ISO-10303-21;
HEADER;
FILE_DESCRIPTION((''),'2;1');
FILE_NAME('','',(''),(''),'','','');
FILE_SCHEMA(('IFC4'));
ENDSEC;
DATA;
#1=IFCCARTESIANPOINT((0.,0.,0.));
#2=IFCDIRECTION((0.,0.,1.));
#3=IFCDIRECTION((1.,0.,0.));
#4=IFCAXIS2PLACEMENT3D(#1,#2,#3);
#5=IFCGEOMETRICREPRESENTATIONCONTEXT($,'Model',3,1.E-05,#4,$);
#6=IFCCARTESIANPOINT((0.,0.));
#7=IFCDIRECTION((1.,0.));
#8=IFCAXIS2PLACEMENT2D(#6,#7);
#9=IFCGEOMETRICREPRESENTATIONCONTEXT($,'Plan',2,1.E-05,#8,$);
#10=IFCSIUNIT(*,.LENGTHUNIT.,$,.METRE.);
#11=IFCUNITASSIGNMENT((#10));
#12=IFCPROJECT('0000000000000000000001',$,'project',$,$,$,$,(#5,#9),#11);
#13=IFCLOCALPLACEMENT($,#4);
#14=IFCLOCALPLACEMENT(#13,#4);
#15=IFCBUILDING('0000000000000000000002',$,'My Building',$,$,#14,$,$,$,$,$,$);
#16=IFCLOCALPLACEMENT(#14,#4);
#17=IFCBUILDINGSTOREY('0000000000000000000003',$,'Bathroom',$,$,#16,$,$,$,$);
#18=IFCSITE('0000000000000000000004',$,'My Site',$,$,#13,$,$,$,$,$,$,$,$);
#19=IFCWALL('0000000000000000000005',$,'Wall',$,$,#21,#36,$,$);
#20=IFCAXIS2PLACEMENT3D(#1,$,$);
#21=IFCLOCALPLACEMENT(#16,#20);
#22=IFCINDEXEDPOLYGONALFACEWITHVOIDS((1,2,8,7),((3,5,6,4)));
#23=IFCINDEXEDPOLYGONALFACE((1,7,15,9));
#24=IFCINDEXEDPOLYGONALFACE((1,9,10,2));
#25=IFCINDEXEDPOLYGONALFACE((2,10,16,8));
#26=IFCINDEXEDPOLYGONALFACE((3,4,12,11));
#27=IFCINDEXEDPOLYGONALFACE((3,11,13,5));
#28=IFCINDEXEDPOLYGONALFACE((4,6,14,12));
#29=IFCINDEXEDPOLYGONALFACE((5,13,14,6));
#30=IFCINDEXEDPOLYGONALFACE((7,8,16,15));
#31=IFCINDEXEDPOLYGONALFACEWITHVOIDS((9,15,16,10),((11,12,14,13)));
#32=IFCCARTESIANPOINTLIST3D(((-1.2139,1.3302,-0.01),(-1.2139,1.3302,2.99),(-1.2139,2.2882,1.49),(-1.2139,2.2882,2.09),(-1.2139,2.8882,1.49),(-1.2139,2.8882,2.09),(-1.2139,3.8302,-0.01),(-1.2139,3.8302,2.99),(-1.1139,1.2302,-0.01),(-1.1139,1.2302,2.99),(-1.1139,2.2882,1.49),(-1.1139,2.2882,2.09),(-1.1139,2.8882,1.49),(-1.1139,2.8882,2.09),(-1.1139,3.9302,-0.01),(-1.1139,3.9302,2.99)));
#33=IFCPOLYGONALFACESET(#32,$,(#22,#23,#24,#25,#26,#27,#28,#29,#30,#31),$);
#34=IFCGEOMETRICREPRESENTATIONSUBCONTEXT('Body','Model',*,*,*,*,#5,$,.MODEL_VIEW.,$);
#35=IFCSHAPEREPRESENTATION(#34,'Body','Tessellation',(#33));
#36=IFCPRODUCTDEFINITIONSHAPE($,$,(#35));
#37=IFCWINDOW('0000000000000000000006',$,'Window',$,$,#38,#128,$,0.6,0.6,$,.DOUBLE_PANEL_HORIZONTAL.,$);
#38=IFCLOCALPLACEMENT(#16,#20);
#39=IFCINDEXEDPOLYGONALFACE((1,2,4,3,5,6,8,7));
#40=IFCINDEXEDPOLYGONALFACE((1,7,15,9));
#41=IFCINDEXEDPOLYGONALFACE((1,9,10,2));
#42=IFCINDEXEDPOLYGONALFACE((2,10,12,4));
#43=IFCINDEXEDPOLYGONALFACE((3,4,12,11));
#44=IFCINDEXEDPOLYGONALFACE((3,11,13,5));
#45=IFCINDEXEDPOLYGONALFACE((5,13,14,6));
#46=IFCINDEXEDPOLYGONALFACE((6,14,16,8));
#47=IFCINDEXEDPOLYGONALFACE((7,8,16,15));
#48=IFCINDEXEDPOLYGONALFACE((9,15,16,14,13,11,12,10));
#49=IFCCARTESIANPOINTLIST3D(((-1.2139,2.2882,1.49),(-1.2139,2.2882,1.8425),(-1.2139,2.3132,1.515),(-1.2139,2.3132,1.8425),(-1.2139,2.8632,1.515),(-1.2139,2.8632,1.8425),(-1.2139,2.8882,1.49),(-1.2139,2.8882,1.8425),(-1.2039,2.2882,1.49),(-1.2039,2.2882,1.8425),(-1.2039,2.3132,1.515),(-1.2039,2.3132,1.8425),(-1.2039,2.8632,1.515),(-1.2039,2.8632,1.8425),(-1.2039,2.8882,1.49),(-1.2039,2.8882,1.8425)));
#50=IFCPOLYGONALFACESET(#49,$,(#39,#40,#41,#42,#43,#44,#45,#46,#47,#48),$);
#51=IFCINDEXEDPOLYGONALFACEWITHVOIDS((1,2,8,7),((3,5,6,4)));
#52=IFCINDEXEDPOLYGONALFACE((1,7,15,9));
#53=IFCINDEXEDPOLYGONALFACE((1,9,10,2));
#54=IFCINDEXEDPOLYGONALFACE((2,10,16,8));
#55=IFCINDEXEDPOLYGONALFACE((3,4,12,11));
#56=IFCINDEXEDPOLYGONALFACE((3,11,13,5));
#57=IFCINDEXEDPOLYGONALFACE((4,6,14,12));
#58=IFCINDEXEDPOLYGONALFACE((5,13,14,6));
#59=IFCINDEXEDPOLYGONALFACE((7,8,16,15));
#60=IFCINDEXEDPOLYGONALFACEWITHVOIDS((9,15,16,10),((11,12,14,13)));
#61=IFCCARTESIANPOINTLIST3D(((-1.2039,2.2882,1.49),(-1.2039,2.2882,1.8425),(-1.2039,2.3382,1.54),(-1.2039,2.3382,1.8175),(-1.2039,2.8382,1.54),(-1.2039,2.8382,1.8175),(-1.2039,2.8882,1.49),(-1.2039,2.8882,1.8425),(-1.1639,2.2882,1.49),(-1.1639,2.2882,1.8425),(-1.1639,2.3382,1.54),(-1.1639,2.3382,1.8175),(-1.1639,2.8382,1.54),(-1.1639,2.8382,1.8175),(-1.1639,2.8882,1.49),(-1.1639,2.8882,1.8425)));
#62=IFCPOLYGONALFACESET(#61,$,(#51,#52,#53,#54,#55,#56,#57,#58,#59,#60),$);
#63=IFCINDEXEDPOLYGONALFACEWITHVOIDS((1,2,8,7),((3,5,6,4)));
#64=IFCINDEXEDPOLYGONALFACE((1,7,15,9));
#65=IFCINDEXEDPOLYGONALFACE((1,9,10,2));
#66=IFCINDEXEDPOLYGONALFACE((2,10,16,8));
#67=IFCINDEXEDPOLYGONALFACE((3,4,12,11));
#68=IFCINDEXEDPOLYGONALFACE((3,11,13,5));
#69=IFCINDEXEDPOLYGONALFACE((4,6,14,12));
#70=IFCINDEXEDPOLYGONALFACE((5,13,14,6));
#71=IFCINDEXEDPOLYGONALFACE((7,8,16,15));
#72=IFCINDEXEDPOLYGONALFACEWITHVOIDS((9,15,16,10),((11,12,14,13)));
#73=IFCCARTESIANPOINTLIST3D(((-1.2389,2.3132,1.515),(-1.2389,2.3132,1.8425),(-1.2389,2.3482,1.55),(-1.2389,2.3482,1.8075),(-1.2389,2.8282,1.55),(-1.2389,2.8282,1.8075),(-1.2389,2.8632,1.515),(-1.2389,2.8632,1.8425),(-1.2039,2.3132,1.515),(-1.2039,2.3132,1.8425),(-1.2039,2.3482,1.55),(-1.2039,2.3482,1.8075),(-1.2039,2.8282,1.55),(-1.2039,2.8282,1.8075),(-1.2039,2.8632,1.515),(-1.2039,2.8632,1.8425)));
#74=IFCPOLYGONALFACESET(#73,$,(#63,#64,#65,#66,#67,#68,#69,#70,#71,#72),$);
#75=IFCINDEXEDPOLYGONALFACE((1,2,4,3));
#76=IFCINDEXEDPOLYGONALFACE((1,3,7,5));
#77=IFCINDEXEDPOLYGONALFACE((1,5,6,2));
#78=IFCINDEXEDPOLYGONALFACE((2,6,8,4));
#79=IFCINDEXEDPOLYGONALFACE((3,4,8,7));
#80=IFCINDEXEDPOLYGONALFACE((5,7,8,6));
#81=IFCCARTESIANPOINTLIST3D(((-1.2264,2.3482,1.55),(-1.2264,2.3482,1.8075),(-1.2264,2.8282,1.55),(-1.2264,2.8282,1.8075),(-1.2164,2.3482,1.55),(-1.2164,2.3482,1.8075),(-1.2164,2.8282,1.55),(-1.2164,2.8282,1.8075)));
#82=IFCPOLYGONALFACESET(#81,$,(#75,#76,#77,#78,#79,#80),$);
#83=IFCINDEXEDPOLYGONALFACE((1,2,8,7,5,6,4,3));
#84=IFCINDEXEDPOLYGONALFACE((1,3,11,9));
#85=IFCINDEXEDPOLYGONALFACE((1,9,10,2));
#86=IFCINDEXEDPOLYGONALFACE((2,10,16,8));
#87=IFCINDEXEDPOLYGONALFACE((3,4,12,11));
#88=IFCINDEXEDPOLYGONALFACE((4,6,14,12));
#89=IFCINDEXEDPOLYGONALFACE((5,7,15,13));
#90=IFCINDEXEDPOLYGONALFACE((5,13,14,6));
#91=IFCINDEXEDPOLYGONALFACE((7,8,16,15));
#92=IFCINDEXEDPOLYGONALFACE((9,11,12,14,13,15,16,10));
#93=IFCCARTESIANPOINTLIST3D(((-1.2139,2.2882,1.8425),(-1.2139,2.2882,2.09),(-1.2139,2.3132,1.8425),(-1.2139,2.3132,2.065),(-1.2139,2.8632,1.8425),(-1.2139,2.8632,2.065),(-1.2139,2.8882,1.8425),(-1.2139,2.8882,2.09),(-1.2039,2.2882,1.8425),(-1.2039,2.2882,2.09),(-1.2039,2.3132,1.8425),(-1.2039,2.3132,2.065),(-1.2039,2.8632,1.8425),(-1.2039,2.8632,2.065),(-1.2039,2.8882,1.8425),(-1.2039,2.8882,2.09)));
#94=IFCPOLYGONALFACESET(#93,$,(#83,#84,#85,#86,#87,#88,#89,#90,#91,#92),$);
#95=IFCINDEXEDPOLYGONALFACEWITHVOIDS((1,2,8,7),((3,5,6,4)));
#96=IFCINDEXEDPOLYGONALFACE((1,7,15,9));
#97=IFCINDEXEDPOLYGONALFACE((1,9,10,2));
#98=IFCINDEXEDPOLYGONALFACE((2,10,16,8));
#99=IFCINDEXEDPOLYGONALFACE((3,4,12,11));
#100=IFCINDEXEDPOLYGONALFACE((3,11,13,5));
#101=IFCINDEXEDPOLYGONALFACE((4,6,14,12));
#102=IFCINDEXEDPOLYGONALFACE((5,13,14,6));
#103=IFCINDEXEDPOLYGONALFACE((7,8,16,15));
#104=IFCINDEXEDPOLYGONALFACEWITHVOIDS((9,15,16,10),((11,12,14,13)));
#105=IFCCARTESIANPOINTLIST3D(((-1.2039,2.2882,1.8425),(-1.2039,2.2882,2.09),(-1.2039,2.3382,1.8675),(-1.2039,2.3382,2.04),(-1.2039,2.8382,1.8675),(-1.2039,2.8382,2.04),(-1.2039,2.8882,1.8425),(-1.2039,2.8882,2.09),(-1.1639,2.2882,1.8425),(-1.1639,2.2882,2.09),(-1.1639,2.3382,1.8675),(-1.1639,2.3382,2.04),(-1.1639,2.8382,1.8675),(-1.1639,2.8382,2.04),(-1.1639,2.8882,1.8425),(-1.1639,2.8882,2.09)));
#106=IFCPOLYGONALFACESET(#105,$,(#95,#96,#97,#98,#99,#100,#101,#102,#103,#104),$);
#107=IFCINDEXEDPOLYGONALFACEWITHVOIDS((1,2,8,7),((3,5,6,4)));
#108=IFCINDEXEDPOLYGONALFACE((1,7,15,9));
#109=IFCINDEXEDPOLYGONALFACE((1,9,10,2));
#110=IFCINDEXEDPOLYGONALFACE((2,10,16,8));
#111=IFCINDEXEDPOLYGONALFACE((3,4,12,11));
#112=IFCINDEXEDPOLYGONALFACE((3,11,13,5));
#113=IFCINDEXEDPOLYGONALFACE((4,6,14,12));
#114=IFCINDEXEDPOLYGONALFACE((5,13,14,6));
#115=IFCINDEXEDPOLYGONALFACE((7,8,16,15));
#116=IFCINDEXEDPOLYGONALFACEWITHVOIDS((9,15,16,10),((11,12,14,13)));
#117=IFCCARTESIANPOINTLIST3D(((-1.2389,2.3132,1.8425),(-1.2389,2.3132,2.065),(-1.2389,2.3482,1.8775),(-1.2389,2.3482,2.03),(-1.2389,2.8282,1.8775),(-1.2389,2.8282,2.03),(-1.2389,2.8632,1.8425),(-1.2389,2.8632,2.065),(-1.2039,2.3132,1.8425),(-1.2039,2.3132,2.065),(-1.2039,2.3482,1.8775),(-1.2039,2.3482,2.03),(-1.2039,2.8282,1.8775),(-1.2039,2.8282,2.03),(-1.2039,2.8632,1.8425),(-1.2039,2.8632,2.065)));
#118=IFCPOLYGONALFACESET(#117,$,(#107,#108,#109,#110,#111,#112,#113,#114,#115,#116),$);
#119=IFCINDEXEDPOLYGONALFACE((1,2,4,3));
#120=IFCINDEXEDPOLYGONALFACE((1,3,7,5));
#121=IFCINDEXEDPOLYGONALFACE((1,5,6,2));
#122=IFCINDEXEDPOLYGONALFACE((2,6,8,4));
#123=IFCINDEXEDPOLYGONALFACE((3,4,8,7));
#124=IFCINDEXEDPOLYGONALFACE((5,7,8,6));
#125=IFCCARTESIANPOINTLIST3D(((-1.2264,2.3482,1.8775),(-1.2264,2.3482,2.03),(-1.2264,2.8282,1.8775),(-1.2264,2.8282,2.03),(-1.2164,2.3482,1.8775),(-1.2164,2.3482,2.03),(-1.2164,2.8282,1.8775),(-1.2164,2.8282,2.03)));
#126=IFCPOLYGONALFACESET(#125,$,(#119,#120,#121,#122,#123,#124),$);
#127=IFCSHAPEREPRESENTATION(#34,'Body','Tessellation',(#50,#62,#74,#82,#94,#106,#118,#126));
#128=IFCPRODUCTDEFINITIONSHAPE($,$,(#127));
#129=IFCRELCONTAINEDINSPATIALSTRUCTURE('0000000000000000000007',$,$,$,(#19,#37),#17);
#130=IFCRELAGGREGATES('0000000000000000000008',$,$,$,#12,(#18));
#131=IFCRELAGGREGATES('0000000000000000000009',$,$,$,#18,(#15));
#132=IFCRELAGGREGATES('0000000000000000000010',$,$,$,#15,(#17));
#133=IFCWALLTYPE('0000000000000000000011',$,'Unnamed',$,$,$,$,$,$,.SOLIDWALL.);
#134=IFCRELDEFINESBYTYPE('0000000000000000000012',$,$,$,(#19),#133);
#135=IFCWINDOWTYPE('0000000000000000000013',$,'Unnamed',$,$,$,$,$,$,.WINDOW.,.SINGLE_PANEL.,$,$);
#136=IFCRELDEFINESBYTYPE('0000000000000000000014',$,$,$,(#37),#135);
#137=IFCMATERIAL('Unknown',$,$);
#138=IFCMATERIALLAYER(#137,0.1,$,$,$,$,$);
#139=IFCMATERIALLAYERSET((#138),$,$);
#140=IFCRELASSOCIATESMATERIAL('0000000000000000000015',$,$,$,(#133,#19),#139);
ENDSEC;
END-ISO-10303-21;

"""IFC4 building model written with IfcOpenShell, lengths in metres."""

from ifc_helpers import new_model, entity, si_unit, frame, origin_with_axes, origin_2d_with_axis, place, context, subcontext, project, spatial, line, indexed_curve, outline, extrude, shape, source, transform, mapped, material, layer, layer_set, layer_usage, type_object, type_shapes, element, fill, save


model = new_model("IFC4")

# Units and contexts
model_context = context("Model", 3, precision=1e-05, world=origin_with_axes())
plan_context = context("Plan", 2, precision=1e-05, world=origin_2d_with_axis())
body_context_1 = subcontext(model_context, "Body", "Model", "MODEL_VIEW")
body_context_2 = subcontext(plan_context, "Body", "Plan", "PLAN_VIEW")
ifc_project = project(units=[si_unit("LENGTHUNIT", "METRE")], contexts=[model_context, plan_context])

# Site, building, storey
site_placement = place(None, origin_with_axes())
site = spatial("IfcSite", under=ifc_project, at=site_placement, Name="My Site")
building_placement = place(site_placement, origin_with_axes())
building = spatial("IfcBuilding", under=site, at=building_placement, Name="My Building")
storey_placement = place(building_placement, origin_with_axes())
storey = spatial("IfcBuildingStorey", under=building, at=storey_placement, Name="Bathroom")

# Shared definitions
ifc_material = material(Name="Unknown")

# Shared definitions
ifc_layer_1 = layer(ifc_material, 0.1)
ifc_layer_set_1 = layer_set([ifc_layer_1])
wall_type = type_object("IfcWallType", Name="Unnamed", PredefinedType="SOLIDWALL", material=ifc_layer_set_1)

# Wall, opening, window
ifc_layer_usage_1 = layer_usage(ifc_layer_set_1, "AXIS2", "POSITIVE", 0.0)
wall_1_placement = place(storey_placement, frame((-1.2139, 3.8302, -0.01), z_axis=(0.0, 0.0, 1.0), x_axis=(0.0, -1.0, 0.0)))
wall_1 = element("IfcWall", 1, at=wall_1_placement, inside=storey, type_object=wall_type, material=ifc_layer_usage_1, Name="Wall", context=body_context_1, shape_type="SweptSolid", body=[
    extrude(outline(indexed_curve([(0.0, 0.0), (-0.1, 0.1), (2.6, 0.1), (2.5, 0.0)], segments=[line(1, 2, 3, 4, 1)])), origin_with_axes(), (0.0, 0.0, 1.0), 3.0),
])
shared_shape_1 = source(origin_with_axes(), body_context_1, "Body", "SweptSolid", [
    extrude(outline(indexed_curve([(0.0, 0.0), (0.6, 0.0), (0.6, 0.6), (0.0, 0.6)], segments=[line(1, 2, 3, 4, 1)])), frame((0.0, -0.6, 0.0), z_axis=(0.0, -1.0, 0.0), x_axis=(1.0, 0.0, 0.0)), (0.0, 0.0, -1.0), 1.2),
])
opening_1_placement = place(wall_1_placement, frame((1.542, 0.1, 1.5), z_axis=(0.0, 0.0, 1.0), x_axis=(-1.0, 0.0, 0.0)))
opening_1 = element("IfcOpeningElement", 2, at=opening_1_placement, cuts=wall_1, PredefinedType="OPENING", context=body_context_1, shape_type="MappedRepresentation", body=[
    mapped(shared_shape_1, transform((0.0, 0.0, 0.0), x_axis=(1.0, 0.0, 0.0), y_axis=(0.0, 1.0, 0.0), z_axis=(0.0, 0.0, 1.0), scale=1.0)),
])
window_type = type_object("IfcWindowType", Name="Unnamed", PartitioningType="SINGLE_PANEL", PredefinedType="WINDOW")
shared_shape_2 = source(origin_with_axes(), body_context_1, "Body", "SweptSolid", [
    extrude(outline(indexed_curve([(0.6, 0.3525), (0.6, 0.0), (0.0, 0.0), (0.0, 0.3525), (0.025, 0.3525), (0.025, 0.025), (0.575, 0.025), (0.575, 0.3525)], segments=[line(1, 2, 3, 4, 5, 6, 7, 8, 1)])), frame((0.0, 0.09, 0.0), z_axis=(0.0, -1.0, 0.0), x_axis=(1.0, 0.0, 0.0)), (0.0, 0.0, -1.0), 0.01),
    extrude(outline(indexed_curve([(0.0, 0.0), (0.6, 0.0), (0.6, 0.3525), (0.0, 0.3525)], segments=[line(1, 2, 3, 4, 1)]), holes=[indexed_curve([(0.05, 0.05), (0.55, 0.05), (0.55, 0.3275), (0.05, 0.3275)], segments=[line(1, 2, 3, 4, 1)])]), frame((0.0, 0.05, 0.0), z_axis=(0.0, -1.0, 0.0), x_axis=(1.0, 0.0, 0.0)), (0.0, 0.0, -1.0), 0.04),
    extrude(outline(indexed_curve([(0.0, 0.0), (0.55, 0.0), (0.55, 0.3275), (0.0, 0.3275)], segments=[line(1, 2, 3, 4, 1)]), holes=[indexed_curve([(0.035, 0.035), (0.515, 0.035), (0.515, 0.2925), (0.035, 0.2925)], segments=[line(1, 2, 3, 4, 1)])]), frame((0.025, 0.09, 0.025), z_axis=(0.0, -1.0, 0.0), x_axis=(1.0, 0.0, 0.0)), (0.0, 0.0, -1.0), 0.035),
    extrude(outline(indexed_curve([(0.035, 0.035), (0.515, 0.035), (0.515, 0.2925), (0.035, 0.2925)], segments=[line(1, 2, 3, 4, 1)])), frame((0.025, 0.1025, 0.025), z_axis=(0.0, -1.0, 0.0), x_axis=(1.0, 0.0, 0.0)), (0.0, 0.0, -1.0), 0.01),
    extrude(outline(indexed_curve([(0.0, 0.0), (0.0, 0.2475), (0.6, 0.2475), (0.6, 0.0), (0.575, 0.0), (0.575, 0.2225), (0.025, 0.2225), (0.025, 0.0)], segments=[line(1, 2, 3, 4, 5, 6, 7, 8, 1)])), frame((0.0, 0.09, 0.3525), z_axis=(0.0, -1.0, 0.0), x_axis=(1.0, 0.0, 0.0)), (0.0, 0.0, -1.0), 0.01),
    extrude(outline(indexed_curve([(0.0, 0.0), (0.6, 0.0), (0.6, 0.2475), (0.0, 0.2475)], segments=[line(1, 2, 3, 4, 1)]), holes=[indexed_curve([(0.05, 0.025), (0.55, 0.025), (0.55, 0.1975), (0.05, 0.1975)], segments=[line(1, 2, 3, 4, 1)])]), frame((0.0, 0.05, 0.3525), z_axis=(0.0, -1.0, 0.0), x_axis=(1.0, 0.0, 0.0)), (0.0, 0.0, -1.0), 0.04),
    extrude(outline(indexed_curve([(0.0, 0.0), (0.55, 0.0), (0.55, 0.2225), (0.0, 0.2225)], segments=[line(1, 2, 3, 4, 1)]), holes=[indexed_curve([(0.035, 0.035), (0.515, 0.035), (0.515, 0.1875), (0.035, 0.1875)], segments=[line(1, 2, 3, 4, 1)])]), frame((0.025, 0.09, 0.3525), z_axis=(0.0, -1.0, 0.0), x_axis=(1.0, 0.0, 0.0)), (0.0, 0.0, -1.0), 0.035),
    extrude(outline(indexed_curve([(0.035, 0.035), (0.515, 0.035), (0.515, 0.1875), (0.035, 0.1875)], segments=[line(1, 2, 3, 4, 1)])), frame((0.025, 0.1025, 0.3525), z_axis=(0.0, -1.0, 0.0), x_axis=(1.0, 0.0, 0.0)), (0.0, 0.0, -1.0), 0.01),
])
shared_shape_3 = source(origin_with_axes(), body_context_2, "Body", "Curve2D", [
    entity("IfcIndexedPolyCurve", entity("IfcCartesianPointList2D", [[0.05, 0.05], [0.55, 0.05]])),
    entity("IfcIndexedPolyCurve", entity("IfcCartesianPointList2D", [[0.0, 0.1], [0.025, 0.1], [0.025, 0.09], [0.05, 0.09], [0.05, 0.05], [0.0, 0.05]]), [entity("IfcLineIndex", [1, 2, 3, 4, 5, 6, 1])]),
    entity("IfcIndexedPolyCurve", entity("IfcCartesianPointList2D", [[0.6, 0.1], [0.575, 0.1], [0.575, 0.09], [0.55, 0.09], [0.55, 0.05], [0.6, 0.05]]), [entity("IfcLineIndex", [1, 2, 3, 4, 5, 6, 1])]),
    entity("IfcIndexedPolyCurve", entity("IfcCartesianPointList2D", [[0.025, 0.09], [0.06, 0.09], [0.06, 0.125], [0.025, 0.125]]), [entity("IfcLineIndex", [1, 2, 3, 4, 1])]),
    entity("IfcIndexedPolyCurve", entity("IfcCartesianPointList2D", [[0.575, 0.09], [0.54, 0.09], [0.54, 0.125], [0.575, 0.125]]), [entity("IfcLineIndex", [1, 2, 3, 4, 1])]),
    entity("IfcIndexedPolyCurve", entity("IfcCartesianPointList2D", [[0.06, 0.09], [0.54, 0.09]])),
    entity("IfcIndexedPolyCurve", entity("IfcCartesianPointList2D", [[0.06, 0.125], [0.54, 0.125]])),
    entity("IfcIndexedPolyCurve", entity("IfcCartesianPointList2D", [[0.06, 0.1075], [0.54, 0.1075]])),
])
type_shapes(window_type, [shared_shape_2, shared_shape_3])
window_1_placement = place(opening_1_placement, frame((0.0, 0.0, 0.0), z_axis=(0.0, 0.0, 1.0), x_axis=(1.0, 0.0, 0.0)))
window_1 = element("IfcWindow", 3, at=window_1_placement, inside=storey, type_object=window_type, Name="Window", OverallHeight=0.6, OverallWidth=0.6, PartitioningType="DOUBLE_PANEL_HORIZONTAL", shapes=[
    shape(body_context_1, "Body", "MappedRepresentation", [mapped(shared_shape_2, transform((0.0, 0.0, 0.0), x_axis=(1.0, 0.0, 0.0), y_axis=(0.0, 1.0, 0.0), z_axis=(0.0, 0.0, 1.0), scale=1.0))]),
    shape(body_context_2, "Body", "MappedRepresentation", [mapped(shared_shape_3, transform((0.0, 0.0, 0.0), x_axis=(1.0, 0.0, 0.0), y_axis=(0.0, 1.0, 0.0), z_axis=(0.0, 0.0, 1.0), scale=1.0))]),
])
fill(opening_1, window_1)

save(model, "model.ifc")
